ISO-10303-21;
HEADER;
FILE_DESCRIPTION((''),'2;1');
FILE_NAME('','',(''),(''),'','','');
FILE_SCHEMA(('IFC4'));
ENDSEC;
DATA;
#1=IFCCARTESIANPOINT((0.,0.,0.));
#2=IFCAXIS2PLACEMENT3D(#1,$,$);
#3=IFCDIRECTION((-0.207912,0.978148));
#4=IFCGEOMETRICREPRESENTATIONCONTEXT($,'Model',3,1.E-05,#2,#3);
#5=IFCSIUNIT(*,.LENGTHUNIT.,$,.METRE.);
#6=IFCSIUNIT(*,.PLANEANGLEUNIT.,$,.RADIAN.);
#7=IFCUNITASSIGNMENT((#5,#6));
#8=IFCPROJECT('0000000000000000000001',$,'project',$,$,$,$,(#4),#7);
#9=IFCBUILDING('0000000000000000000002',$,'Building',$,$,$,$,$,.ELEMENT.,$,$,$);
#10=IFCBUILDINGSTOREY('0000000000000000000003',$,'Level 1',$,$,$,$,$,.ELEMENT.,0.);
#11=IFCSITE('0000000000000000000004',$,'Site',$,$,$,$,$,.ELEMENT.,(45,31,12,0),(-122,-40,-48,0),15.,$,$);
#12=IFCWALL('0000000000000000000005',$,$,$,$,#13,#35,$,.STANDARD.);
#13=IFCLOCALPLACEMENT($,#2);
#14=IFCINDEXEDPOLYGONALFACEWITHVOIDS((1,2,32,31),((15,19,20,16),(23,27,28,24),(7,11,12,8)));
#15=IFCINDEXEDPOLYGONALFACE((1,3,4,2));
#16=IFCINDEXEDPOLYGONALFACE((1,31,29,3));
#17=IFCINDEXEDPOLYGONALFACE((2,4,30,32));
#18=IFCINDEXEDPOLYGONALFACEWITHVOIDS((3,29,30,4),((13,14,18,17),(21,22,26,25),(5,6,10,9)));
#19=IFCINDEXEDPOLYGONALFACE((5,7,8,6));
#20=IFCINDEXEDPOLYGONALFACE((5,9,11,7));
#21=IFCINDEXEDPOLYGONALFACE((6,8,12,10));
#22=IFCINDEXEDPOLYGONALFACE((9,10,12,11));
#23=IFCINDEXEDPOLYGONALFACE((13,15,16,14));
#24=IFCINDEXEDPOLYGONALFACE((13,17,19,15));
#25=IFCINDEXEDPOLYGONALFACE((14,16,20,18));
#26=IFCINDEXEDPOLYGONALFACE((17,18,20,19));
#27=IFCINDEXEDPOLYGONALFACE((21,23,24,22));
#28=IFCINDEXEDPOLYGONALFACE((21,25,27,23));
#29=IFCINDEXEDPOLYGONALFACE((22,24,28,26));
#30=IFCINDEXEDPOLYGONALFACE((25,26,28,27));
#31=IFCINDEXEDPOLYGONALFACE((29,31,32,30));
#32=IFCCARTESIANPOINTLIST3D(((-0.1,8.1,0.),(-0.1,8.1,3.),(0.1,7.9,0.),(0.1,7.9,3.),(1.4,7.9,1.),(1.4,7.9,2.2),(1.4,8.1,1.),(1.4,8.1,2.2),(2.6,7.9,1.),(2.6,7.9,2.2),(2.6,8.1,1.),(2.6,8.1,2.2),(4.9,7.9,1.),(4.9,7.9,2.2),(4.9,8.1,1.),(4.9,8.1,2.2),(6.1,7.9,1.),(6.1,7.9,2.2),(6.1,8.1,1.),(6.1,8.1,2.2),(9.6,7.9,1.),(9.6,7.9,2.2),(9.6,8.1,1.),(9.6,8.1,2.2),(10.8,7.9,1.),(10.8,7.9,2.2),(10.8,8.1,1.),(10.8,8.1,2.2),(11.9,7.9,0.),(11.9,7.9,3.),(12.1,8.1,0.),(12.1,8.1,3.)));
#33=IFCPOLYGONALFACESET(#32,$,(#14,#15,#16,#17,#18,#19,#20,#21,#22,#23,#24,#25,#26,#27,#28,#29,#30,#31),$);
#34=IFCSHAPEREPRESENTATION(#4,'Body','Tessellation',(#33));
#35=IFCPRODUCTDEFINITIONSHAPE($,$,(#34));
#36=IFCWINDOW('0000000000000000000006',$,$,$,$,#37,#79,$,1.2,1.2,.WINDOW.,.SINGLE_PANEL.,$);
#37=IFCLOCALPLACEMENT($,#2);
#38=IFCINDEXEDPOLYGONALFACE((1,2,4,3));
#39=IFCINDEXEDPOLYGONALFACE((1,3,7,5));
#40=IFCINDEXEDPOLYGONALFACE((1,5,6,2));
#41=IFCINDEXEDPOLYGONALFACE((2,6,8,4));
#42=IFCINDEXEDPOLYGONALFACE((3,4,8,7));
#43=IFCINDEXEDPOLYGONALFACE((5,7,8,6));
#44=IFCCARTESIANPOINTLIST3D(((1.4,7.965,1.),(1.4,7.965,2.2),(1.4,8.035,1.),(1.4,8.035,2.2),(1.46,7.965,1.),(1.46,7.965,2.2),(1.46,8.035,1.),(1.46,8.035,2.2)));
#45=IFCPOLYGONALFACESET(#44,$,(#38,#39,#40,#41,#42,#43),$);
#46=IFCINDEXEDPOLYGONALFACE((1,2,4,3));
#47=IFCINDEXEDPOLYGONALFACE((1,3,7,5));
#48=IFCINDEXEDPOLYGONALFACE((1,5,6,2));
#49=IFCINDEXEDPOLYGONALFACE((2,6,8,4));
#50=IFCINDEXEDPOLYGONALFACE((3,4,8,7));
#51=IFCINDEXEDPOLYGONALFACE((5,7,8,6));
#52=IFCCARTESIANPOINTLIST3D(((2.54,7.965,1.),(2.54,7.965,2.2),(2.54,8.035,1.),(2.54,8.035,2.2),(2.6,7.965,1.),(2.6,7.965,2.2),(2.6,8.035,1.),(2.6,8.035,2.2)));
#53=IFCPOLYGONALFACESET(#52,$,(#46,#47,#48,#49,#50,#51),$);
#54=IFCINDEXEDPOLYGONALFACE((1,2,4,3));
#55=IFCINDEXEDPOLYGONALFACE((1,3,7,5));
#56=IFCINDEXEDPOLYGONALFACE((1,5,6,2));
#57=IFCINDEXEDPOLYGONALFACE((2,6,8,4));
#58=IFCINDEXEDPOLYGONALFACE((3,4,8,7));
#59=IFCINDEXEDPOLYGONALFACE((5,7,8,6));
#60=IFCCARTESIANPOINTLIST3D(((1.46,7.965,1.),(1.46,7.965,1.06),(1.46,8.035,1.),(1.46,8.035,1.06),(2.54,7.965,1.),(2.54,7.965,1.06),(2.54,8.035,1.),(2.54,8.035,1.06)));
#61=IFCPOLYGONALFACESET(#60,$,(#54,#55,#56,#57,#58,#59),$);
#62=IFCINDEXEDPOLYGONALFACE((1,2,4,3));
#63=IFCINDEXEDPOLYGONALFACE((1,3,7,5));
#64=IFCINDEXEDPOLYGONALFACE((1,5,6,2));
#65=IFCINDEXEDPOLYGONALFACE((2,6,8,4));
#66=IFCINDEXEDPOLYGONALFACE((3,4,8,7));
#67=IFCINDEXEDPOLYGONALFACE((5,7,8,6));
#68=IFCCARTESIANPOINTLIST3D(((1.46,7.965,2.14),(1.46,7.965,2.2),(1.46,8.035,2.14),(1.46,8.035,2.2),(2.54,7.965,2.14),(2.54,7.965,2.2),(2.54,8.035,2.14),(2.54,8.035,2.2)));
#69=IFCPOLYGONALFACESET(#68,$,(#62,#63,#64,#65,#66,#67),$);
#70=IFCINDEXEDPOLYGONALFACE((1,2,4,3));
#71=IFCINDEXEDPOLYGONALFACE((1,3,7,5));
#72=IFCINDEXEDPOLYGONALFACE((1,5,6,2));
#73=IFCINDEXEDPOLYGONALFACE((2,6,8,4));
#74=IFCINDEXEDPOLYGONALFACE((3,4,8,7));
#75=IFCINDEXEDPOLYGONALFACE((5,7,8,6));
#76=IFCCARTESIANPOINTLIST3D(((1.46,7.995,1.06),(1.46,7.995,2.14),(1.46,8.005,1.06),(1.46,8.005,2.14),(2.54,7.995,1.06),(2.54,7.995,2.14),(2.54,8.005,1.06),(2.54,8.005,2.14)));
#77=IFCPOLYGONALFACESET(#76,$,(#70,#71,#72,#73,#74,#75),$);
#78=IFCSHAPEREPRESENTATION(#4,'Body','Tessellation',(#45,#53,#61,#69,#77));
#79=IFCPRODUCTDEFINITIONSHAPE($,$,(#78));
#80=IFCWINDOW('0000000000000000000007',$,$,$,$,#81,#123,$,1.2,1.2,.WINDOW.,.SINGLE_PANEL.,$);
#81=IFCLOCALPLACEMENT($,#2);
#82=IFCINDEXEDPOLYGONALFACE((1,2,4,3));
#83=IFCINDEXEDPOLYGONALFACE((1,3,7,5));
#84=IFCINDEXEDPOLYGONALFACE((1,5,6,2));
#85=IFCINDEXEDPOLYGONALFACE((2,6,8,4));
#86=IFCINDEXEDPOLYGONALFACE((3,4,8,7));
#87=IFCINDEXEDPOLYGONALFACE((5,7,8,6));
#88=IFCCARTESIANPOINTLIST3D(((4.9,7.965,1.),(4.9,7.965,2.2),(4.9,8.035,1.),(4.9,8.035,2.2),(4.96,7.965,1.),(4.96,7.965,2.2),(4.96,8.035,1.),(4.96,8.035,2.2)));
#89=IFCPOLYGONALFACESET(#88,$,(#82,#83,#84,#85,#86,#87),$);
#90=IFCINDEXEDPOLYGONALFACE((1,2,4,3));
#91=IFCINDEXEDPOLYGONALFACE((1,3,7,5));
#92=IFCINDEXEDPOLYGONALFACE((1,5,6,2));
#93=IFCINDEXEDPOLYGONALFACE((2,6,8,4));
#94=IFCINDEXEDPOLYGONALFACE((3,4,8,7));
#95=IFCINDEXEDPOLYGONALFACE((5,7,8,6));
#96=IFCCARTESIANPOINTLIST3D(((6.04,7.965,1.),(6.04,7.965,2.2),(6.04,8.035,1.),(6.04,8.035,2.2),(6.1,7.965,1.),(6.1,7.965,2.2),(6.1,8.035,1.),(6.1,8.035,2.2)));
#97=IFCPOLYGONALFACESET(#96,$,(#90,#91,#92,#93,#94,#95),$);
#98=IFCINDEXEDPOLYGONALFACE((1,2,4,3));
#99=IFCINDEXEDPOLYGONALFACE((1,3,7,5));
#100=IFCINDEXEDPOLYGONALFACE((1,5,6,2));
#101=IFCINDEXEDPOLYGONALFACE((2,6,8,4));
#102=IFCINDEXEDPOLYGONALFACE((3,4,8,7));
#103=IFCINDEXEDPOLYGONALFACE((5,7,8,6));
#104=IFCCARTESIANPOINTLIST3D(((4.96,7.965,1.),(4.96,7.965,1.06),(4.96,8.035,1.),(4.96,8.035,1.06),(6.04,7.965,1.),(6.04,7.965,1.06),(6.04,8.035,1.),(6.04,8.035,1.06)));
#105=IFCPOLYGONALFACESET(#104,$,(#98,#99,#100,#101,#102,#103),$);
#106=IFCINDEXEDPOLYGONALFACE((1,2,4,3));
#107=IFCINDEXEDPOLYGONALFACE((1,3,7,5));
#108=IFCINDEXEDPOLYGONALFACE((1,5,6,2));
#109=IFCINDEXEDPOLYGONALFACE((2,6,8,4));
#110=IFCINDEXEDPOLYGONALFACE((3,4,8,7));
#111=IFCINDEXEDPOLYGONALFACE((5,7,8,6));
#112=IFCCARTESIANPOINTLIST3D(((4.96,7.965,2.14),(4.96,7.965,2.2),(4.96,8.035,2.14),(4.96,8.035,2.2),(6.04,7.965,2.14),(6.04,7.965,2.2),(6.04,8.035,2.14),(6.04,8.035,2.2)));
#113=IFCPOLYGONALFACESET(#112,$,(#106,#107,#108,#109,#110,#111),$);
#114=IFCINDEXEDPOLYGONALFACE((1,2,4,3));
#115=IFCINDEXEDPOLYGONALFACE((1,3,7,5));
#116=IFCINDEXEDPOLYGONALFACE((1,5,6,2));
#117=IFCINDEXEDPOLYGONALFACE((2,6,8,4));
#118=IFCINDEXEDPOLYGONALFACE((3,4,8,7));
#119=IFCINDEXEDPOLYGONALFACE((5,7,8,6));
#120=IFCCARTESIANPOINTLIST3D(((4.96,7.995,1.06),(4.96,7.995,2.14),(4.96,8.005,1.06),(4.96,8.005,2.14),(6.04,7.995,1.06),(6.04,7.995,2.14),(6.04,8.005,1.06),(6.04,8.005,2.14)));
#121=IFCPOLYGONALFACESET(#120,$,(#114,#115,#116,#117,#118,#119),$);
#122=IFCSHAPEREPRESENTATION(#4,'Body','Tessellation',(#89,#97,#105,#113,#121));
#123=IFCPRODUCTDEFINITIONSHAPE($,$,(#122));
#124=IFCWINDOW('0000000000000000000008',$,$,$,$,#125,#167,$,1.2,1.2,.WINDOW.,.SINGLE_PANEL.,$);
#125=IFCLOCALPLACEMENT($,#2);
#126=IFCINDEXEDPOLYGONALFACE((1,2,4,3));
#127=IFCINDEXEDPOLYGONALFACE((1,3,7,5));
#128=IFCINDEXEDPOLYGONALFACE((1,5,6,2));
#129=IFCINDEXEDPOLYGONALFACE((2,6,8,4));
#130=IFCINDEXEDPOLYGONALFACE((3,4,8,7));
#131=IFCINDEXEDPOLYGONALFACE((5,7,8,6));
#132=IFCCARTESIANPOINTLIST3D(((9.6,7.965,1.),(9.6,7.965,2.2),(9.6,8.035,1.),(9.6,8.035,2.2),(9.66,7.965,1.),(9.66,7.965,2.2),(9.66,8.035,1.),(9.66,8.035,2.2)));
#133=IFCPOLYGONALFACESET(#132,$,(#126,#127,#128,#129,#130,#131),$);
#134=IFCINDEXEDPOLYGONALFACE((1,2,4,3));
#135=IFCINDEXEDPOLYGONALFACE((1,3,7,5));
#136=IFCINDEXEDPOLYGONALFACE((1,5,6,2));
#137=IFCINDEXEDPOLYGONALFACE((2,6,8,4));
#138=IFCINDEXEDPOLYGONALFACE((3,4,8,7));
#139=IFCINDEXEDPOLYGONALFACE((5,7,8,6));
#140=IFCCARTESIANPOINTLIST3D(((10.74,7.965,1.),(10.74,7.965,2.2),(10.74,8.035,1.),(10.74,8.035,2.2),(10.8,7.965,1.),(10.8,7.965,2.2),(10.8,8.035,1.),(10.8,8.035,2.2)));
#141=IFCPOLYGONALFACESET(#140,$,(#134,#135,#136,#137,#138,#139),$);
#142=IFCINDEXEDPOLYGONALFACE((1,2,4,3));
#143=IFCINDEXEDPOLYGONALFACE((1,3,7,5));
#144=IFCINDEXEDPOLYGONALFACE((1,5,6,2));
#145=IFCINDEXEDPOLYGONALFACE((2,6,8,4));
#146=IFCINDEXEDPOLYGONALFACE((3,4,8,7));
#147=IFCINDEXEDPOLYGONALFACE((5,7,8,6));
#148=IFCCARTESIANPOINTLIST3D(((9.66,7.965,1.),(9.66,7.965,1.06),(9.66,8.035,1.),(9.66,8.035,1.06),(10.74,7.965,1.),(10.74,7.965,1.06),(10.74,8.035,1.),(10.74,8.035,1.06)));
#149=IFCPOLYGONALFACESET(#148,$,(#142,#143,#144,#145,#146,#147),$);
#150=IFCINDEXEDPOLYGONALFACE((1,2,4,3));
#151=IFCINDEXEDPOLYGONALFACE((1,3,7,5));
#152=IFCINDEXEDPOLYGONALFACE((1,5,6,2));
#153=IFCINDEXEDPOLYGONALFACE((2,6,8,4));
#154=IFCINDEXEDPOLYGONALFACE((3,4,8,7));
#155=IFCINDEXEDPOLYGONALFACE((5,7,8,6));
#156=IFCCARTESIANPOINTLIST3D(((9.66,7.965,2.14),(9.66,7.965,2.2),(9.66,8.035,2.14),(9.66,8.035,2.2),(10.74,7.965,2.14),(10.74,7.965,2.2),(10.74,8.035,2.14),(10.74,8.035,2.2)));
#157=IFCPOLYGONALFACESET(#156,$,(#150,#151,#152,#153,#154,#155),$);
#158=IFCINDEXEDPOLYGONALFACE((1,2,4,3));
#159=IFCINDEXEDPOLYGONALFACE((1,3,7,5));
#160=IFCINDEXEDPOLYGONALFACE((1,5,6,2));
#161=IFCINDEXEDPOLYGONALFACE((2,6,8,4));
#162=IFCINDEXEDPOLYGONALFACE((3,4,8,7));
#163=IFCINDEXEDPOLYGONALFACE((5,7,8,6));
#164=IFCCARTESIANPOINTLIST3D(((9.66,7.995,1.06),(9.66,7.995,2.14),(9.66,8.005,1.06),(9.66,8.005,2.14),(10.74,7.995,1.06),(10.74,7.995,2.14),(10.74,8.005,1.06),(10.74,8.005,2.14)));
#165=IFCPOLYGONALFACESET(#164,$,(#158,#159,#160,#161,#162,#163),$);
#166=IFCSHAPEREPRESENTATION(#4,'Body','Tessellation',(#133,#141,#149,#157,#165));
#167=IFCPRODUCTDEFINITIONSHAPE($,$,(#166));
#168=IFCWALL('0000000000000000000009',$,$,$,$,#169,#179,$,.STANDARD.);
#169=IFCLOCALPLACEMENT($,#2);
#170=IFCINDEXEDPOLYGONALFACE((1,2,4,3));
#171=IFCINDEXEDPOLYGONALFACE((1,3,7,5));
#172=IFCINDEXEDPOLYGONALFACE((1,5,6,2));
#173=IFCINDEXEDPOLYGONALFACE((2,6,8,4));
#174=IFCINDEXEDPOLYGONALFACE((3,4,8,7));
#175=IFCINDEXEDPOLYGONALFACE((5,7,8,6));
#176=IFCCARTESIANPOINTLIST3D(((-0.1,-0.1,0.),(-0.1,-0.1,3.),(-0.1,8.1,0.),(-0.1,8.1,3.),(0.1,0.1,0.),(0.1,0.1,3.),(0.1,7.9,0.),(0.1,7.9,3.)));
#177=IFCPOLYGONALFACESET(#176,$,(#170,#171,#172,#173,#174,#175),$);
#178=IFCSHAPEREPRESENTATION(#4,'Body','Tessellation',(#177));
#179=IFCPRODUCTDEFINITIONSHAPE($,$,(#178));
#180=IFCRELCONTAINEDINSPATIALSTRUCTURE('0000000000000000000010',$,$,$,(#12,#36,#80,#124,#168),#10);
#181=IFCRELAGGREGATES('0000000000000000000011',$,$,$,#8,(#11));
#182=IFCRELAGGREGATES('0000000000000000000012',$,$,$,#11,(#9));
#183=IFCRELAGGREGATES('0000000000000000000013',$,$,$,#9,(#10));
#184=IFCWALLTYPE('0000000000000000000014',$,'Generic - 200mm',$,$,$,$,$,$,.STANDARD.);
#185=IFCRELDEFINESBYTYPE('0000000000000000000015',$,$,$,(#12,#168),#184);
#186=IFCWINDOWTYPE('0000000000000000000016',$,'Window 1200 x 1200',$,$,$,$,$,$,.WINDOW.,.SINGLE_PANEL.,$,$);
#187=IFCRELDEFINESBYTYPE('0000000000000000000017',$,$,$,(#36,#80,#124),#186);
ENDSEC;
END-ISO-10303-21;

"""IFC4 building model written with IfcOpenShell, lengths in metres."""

from ifc_helpers import new_model, si_unit, direction, frame, frame_2d, origin, origin_with_axes, origin_2d, place, context, project, spatial, polyline, rectangle, outline, extrude, type_object, element, fill, save


model = new_model("IFC4")

# Units and contexts
model_context = context("Model", 3, precision=1e-05, world=origin(), true_north=direction((-0.207912, 0.978148)))
ifc_project = project(units=[si_unit("LENGTHUNIT", "METRE"), si_unit("PLANEANGLEUNIT", "RADIAN")], contexts=[model_context])

# Site, building, storey
site = spatial("IfcSite", under=ifc_project, Name="Site", CompositionType="ELEMENT", RefLatitude=(45, 31, 12, 0), RefLongitude=(-122, -40, -48, 0), RefElevation=15.0)
building = spatial("IfcBuilding", under=site, Name="Building", CompositionType="ELEMENT")
storey = spatial("IfcBuildingStorey", under=building, Name="Level 1", CompositionType="ELEMENT", Elevation=0.0)

# Shared definitions
wall_type = type_object("IfcWallType", Name="Generic - 200mm", PredefinedType="STANDARD")
window_type = type_object("IfcWindowType", Name="Window 1200 x 1200", PartitioningType="SINGLE_PANEL", PredefinedType="WINDOW")

# Wall, openings, windows
wall_1_placement = place(None, frame((0.0, 8.0, 0.0), z_axis=(0.0, 0.0, 1.0), x_axis=(1.0, 0.0, 0.0)))
wall_1 = element("IfcWall", 1, at=wall_1_placement, inside=storey, type_object=wall_type, PredefinedType="STANDARD", context=model_context, shape_type="SweptSolid", body=[
    extrude(outline(polyline([(0.1, -0.1), (11.9, -0.1), (12.1, 0.1), (-0.1, 0.1), (0.1, -0.1)])), origin(), (0.0, 0.0, 1.0), 3.0),
])
opening_1_placement = place(wall_1_placement, frame((2.0, 0.0, 1.0), z_axis=(0.0, 0.0, 1.0), x_axis=(1.0, 0.0, 0.0)))
opening_1 = element("IfcOpeningElement", 2, at=opening_1_placement, cuts=wall_1, PredefinedType="OPENING", context=model_context, shape_type="SweptSolid", body=[
    extrude(rectangle(XDim=1.2, YDim=0.202, at=origin_2d()), origin(), (0.0, 0.0, 1.0), 1.2),
])
opening_2_placement = place(wall_1_placement, frame((5.5, 0.0, 1.0), z_axis=(0.0, 0.0, 1.0), x_axis=(1.0, 0.0, 0.0)))
opening_2 = element("IfcOpeningElement", 3, at=opening_2_placement, cuts=wall_1, PredefinedType="OPENING", context=model_context, shape_type="SweptSolid", body=[
    extrude(rectangle(XDim=1.2, YDim=0.202, at=origin_2d()), origin(), (0.0, 0.0, 1.0), 1.2),
])
opening_3_placement = place(wall_1_placement, frame((10.2, 0.0, 1.0), z_axis=(0.0, 0.0, 1.0), x_axis=(1.0, 0.0, 0.0)))
opening_3 = element("IfcOpeningElement", 4, at=opening_3_placement, cuts=wall_1, PredefinedType="OPENING", context=model_context, shape_type="SweptSolid", body=[
    extrude(rectangle(XDim=1.2, YDim=0.202, at=origin_2d()), origin(), (0.0, 0.0, 1.0), 1.2),
])
window_1_placement = place(opening_1_placement, origin_with_axes())
window_1 = element("IfcWindow", 5, at=window_1_placement, inside=storey, type_object=window_type, OverallHeight=1.2, OverallWidth=1.2, PartitioningType="SINGLE_PANEL", PredefinedType="WINDOW", context=model_context, shape_type="SweptSolid", body=[
    extrude(rectangle(XDim=0.06, YDim=0.07, at=frame_2d((-0.57, 0.0))), origin(), (0.0, 0.0, 1.0), 1.2),
    extrude(rectangle(XDim=0.06, YDim=0.07, at=frame_2d((0.57, 0.0))), origin(), (0.0, 0.0, 1.0), 1.2),
    extrude(rectangle(XDim=1.08, YDim=0.07, at=origin_2d()), origin(), (0.0, 0.0, 1.0), 0.06),
    extrude(rectangle(XDim=1.08, YDim=0.07, at=origin_2d()), frame((0.0, 0.0, 1.14)), (0.0, 0.0, 1.0), 0.06),
    extrude(rectangle(XDim=1.08, YDim=0.01, at=origin_2d()), frame((0.0, 0.0, 0.06)), (0.0, 0.0, 1.0), 1.08),
])
fill(opening_1, window_1)
window_2_placement = place(opening_2_placement, origin_with_axes())
window_2 = element("IfcWindow", 6, at=window_2_placement, inside=storey, type_object=window_type, OverallHeight=1.2, OverallWidth=1.2, PartitioningType="SINGLE_PANEL", PredefinedType="WINDOW", context=model_context, shape_type="SweptSolid", body=[
    extrude(rectangle(XDim=0.06, YDim=0.07, at=frame_2d((-0.57, 0.0))), origin(), (0.0, 0.0, 1.0), 1.2),
    extrude(rectangle(XDim=0.06, YDim=0.07, at=frame_2d((0.57, 0.0))), origin(), (0.0, 0.0, 1.0), 1.2),
    extrude(rectangle(XDim=1.08, YDim=0.07, at=origin_2d()), origin(), (0.0, 0.0, 1.0), 0.06),
    extrude(rectangle(XDim=1.08, YDim=0.07, at=origin_2d()), frame((0.0, 0.0, 1.14)), (0.0, 0.0, 1.0), 0.06),
    extrude(rectangle(XDim=1.08, YDim=0.01, at=origin_2d()), frame((0.0, 0.0, 0.06)), (0.0, 0.0, 1.0), 1.08),
])
fill(opening_2, window_2)
window_3_placement = place(opening_3_placement, origin_with_axes())
window_3 = element("IfcWindow", 7, at=window_3_placement, inside=storey, type_object=window_type, OverallHeight=1.2, OverallWidth=1.2, PartitioningType="SINGLE_PANEL", PredefinedType="WINDOW", context=model_context, shape_type="SweptSolid", body=[
    extrude(rectangle(XDim=0.06, YDim=0.07, at=frame_2d((-0.57, 0.0))), origin(), (0.0, 0.0, 1.0), 1.2),
    extrude(rectangle(XDim=0.06, YDim=0.07, at=frame_2d((0.57, 0.0))), origin(), (0.0, 0.0, 1.0), 1.2),
    extrude(rectangle(XDim=1.08, YDim=0.07, at=origin_2d()), origin(), (0.0, 0.0, 1.0), 0.06),
    extrude(rectangle(XDim=1.08, YDim=0.07, at=origin_2d()), frame((0.0, 0.0, 1.14)), (0.0, 0.0, 1.0), 0.06),
    extrude(rectangle(XDim=1.08, YDim=0.01, at=origin_2d()), frame((0.0, 0.0, 0.06)), (0.0, 0.0, 1.0), 1.08),
])
fill(opening_3, window_3)

# Wall
wall_2_placement = place(None, frame((0.0, 0.0, 0.0), z_axis=(0.0, 0.0, 1.0), x_axis=(0.0, 1.0, 0.0)))
element("IfcWall", 8, at=wall_2_placement, inside=storey, type_object=wall_type, PredefinedType="STANDARD", context=model_context, shape_type="SweptSolid", body=[
    extrude(outline(polyline([(0.1, -0.1), (7.9, -0.1), (8.1, 0.1), (-0.1, 0.1), (0.1, -0.1)])), origin(), (0.0, 0.0, 1.0), 3.0),
])

save(model, "model.ifc")
